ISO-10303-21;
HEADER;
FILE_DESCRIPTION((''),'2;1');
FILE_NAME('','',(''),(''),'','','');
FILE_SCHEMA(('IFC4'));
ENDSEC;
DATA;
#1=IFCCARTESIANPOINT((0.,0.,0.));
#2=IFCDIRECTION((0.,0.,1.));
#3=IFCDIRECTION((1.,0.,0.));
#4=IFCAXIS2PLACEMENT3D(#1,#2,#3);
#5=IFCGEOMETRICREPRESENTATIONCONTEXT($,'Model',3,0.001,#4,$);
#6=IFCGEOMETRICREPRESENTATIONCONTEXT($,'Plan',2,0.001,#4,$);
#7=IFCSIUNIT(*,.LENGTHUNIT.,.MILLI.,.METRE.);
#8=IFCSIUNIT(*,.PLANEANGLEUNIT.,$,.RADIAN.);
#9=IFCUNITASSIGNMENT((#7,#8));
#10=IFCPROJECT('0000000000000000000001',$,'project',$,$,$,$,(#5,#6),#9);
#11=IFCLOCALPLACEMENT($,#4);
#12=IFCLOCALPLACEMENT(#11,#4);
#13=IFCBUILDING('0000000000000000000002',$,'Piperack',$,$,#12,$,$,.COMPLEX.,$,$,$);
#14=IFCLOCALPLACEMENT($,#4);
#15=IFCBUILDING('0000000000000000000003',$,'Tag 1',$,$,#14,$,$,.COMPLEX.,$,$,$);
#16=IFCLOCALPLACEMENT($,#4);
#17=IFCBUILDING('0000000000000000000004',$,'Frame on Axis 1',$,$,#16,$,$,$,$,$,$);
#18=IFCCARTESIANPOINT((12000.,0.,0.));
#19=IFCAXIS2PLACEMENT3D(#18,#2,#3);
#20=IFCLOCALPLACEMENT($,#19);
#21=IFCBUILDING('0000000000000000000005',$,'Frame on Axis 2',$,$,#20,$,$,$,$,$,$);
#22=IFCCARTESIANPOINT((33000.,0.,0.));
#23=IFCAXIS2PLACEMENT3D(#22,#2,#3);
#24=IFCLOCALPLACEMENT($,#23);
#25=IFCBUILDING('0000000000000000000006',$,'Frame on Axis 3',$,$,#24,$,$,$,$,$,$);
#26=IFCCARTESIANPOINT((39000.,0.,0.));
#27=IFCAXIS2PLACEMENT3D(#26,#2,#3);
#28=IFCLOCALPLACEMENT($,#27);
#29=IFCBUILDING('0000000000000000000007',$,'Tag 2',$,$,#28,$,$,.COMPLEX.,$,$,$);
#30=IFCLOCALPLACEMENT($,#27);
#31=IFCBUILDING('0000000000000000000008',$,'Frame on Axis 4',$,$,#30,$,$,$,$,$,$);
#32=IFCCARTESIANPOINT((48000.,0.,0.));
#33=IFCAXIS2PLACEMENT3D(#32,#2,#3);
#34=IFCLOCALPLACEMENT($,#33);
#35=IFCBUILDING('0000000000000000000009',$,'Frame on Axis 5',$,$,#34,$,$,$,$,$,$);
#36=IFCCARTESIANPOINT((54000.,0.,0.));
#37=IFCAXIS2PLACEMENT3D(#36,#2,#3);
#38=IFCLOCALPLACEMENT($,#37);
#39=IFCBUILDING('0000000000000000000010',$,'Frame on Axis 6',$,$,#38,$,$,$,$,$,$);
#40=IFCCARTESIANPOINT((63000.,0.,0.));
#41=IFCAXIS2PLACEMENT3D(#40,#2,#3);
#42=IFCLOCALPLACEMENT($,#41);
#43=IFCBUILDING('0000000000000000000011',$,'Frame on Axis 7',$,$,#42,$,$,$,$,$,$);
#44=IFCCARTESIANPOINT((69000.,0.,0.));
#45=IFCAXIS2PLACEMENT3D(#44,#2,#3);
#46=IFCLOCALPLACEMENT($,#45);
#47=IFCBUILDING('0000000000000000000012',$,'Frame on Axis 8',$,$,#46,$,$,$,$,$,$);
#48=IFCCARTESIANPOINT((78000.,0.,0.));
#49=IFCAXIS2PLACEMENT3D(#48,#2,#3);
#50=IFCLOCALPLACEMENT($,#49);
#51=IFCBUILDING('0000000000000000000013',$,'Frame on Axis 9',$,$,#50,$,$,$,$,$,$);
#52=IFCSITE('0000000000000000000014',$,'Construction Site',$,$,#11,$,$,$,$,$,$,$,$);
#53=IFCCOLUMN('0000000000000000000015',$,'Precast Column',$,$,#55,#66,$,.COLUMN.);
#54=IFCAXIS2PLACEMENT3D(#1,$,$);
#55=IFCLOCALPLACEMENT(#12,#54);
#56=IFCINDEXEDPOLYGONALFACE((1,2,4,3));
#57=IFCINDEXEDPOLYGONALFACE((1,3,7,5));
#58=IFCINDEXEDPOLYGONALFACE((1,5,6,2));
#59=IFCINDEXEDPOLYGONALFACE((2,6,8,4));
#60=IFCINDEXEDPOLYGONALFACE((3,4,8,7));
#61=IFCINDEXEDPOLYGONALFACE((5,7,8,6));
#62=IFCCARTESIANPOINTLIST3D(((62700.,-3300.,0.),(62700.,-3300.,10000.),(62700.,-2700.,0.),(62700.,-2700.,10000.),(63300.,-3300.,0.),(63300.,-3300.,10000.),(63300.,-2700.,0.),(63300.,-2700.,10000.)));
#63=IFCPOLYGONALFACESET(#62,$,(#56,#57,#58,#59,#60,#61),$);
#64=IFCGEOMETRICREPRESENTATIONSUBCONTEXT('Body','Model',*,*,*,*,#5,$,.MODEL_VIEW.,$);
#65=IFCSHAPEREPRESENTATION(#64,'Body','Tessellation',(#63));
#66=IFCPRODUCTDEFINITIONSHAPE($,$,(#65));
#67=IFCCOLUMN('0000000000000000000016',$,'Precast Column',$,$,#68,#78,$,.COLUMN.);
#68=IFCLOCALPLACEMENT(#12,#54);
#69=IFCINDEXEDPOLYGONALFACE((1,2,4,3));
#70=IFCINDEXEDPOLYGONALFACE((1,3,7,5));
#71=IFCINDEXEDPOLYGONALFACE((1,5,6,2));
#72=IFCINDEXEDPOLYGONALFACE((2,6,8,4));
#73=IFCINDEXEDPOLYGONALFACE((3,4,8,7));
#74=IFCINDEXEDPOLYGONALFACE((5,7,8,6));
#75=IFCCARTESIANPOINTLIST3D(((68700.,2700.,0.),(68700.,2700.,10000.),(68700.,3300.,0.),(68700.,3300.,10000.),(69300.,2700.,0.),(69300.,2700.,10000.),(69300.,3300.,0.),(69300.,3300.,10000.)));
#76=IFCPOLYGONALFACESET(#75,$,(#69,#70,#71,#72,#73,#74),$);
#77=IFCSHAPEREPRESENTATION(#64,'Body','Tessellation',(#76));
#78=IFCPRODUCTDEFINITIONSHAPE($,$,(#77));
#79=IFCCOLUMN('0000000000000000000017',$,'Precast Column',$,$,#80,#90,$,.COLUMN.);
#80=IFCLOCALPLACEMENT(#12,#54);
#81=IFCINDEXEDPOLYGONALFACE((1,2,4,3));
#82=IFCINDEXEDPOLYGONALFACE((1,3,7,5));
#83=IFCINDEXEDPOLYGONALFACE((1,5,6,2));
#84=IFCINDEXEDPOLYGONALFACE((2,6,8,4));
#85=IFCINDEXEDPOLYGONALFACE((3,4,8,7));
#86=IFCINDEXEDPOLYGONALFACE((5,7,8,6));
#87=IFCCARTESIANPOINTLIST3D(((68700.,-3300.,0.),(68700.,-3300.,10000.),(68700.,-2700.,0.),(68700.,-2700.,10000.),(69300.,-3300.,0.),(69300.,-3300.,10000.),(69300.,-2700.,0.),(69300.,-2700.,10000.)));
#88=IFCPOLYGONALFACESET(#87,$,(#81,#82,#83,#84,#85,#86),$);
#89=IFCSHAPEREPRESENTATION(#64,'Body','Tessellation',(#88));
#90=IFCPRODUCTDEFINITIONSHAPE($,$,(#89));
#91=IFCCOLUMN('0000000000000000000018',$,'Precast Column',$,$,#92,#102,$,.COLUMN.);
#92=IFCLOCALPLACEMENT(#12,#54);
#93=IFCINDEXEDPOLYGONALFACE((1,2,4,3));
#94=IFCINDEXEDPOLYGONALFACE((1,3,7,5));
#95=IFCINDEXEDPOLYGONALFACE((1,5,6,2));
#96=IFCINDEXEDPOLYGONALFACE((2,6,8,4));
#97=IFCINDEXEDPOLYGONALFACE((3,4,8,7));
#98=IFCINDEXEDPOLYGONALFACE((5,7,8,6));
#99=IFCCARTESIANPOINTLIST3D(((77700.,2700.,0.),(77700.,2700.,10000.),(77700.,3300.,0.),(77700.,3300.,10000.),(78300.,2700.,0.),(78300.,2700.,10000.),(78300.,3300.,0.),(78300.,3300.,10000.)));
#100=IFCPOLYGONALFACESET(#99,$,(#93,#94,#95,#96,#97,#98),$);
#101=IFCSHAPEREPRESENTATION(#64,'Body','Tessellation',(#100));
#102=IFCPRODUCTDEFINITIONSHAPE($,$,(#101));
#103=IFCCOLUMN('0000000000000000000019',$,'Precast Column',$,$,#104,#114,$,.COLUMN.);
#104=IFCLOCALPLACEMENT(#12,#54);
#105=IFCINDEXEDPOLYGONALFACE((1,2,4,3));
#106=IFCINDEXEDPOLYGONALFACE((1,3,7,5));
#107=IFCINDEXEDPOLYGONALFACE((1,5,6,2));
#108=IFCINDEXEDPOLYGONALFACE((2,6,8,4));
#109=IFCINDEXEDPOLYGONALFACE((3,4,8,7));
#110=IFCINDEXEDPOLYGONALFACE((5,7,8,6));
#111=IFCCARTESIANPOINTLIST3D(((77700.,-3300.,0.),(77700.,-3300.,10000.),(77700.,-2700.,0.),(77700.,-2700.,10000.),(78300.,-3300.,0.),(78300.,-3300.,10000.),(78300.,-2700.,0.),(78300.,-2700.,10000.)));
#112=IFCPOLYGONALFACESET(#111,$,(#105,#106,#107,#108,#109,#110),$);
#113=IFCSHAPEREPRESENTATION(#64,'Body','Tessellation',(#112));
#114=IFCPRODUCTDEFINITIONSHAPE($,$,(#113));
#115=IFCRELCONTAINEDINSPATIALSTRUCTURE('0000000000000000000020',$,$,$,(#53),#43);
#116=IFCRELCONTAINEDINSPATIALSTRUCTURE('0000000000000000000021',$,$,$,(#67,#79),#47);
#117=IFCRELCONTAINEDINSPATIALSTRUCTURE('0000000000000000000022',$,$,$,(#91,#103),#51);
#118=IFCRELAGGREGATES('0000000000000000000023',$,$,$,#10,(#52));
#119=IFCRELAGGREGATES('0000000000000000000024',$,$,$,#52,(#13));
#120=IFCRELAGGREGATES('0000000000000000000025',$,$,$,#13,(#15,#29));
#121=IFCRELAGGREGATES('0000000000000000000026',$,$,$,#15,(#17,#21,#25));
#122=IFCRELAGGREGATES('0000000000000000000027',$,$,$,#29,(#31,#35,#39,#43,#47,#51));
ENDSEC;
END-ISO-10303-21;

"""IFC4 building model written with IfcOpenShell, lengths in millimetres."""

from ifc_helpers import new_model, si_unit, frame, origin, origin_with_axes, place, context, subcontext, project, spatial, rectangle, extrude, element, save


model = new_model("IFC4")

# Units and contexts
model_context = context("Model", 3, precision=0.001, world=origin_with_axes())
plan_context = context("Plan", 2, precision=0.001, world=origin_with_axes())
body_context = subcontext(model_context, "Body", "Model", "MODEL_VIEW")
ifc_project = project(units=[si_unit("LENGTHUNIT", "METRE", prefix="MILLI"), si_unit("PLANEANGLEUNIT", "RADIAN")], contexts=[model_context, plan_context])

# Site, buildings
site_placement = place(None, origin_with_axes())
site = spatial("IfcSite", under=ifc_project, at=site_placement, Name="Construction Site")
building_1_placement = place(site_placement, origin_with_axes())
building_1 = spatial("IfcBuilding", under=site, at=building_1_placement, Name="Piperack", CompositionType="COMPLEX")
building_2_placement = place(None, origin_with_axes())
building_2 = spatial("IfcBuilding", under=building_1, at=building_2_placement, Name="Tag 1", CompositionType="COMPLEX")
building_3_placement = place(None, origin_with_axes())
building_3 = spatial("IfcBuilding", under=building_2, at=building_3_placement, Name="Frame on Axis 1")

# Shared definitions
building_4_placement = place(None, frame((12000.0, 0.0, 0.0), z_axis=(0.0, 0.0, 1.0), x_axis=(1.0, 0.0, 0.0)))
building_4 = spatial("IfcBuilding", under=building_2, at=building_4_placement, Name="Frame on Axis 2")

# Shared definitions
building_5_placement = place(None, frame((33000.0, 0.0, 0.0), z_axis=(0.0, 0.0, 1.0), x_axis=(1.0, 0.0, 0.0)))
building_5 = spatial("IfcBuilding", under=building_2, at=building_5_placement, Name="Frame on Axis 3")

# Shared definitions
building_6_placement = place(None, frame((39000.0, 0.0, 0.0), z_axis=(0.0, 0.0, 1.0), x_axis=(1.0, 0.0, 0.0)))
building_6 = spatial("IfcBuilding", under=building_1, at=building_6_placement, Name="Tag 2", CompositionType="COMPLEX")
building_7_placement = place(None, frame((39000.0, 0.0, 0.0), z_axis=(0.0, 0.0, 1.0), x_axis=(1.0, 0.0, 0.0)))
building_7 = spatial("IfcBuilding", under=building_6, at=building_7_placement, Name="Frame on Axis 4")

# Shared definitions
building_8_placement = place(None, frame((48000.0, 0.0, 0.0), z_axis=(0.0, 0.0, 1.0), x_axis=(1.0, 0.0, 0.0)))
building_8 = spatial("IfcBuilding", under=building_6, at=building_8_placement, Name="Frame on Axis 5")

# Shared definitions
building_9_placement = place(None, frame((54000.0, 0.0, 0.0), z_axis=(0.0, 0.0, 1.0), x_axis=(1.0, 0.0, 0.0)))
building_9 = spatial("IfcBuilding", under=building_6, at=building_9_placement, Name="Frame on Axis 6")

# Shared definitions
building_10_placement = place(None, frame((63000.0, 0.0, 0.0), z_axis=(0.0, 0.0, 1.0), x_axis=(1.0, 0.0, 0.0)))
building_10 = spatial("IfcBuilding", under=building_6, at=building_10_placement, Name="Frame on Axis 7")

# Column
for number, where, z_axis, name in (
    (1, (0.0, -3000.0, 0.0), (0.0, 0.0, 1.0), "Precast Column"),
):
    element("IfcColumn", number, at=place(building_10_placement, frame(where, z_axis=z_axis)), inside=building_10, Name=name, PredefinedType="COLUMN", context=body_context, shape_type="SweptSolid", body=[
        extrude(rectangle(XDim=600.0, YDim=600.0), origin(), (0.0, 0.0, 1.0), 10000.0),
    ])

# Shared definitions
building_11_placement = place(None, frame((69000.0, 0.0, 0.0), z_axis=(0.0, 0.0, 1.0), x_axis=(1.0, 0.0, 0.0)))
building_11 = spatial("IfcBuilding", under=building_6, at=building_11_placement, Name="Frame on Axis 8")

# Columns
for number, where, z_axis, name in (
    (2, (0.0, 3000.0, 0.0), (0.0, 0.0, 1.0), "Precast Column"),
    (3, (0.0, -3000.0, 0.0), (0.0, 0.0, 1.0), "Precast Column"),
):
    element("IfcColumn", number, at=place(building_11_placement, frame(where, z_axis=z_axis)), inside=building_11, Name=name, PredefinedType="COLUMN", context=body_context, shape_type="SweptSolid", body=[
        extrude(rectangle(XDim=600.0, YDim=600.0), origin(), (0.0, 0.0, 1.0), 10000.0),
    ])

# Shared definitions
building_12_placement = place(None, frame((78000.0, 0.0, 0.0), z_axis=(0.0, 0.0, 1.0), x_axis=(1.0, 0.0, 0.0)))
building_12 = spatial("IfcBuilding", under=building_6, at=building_12_placement, Name="Frame on Axis 9")

# Columns
for number, where, z_axis, name in (
    (4, (0.0, 3000.0, 0.0), (0.0, 0.0, 1.0), "Precast Column"),
    (5, (0.0, -3000.0, 0.0), (0.0, 0.0, 1.0), "Precast Column"),
):
    element("IfcColumn", number, at=place(building_12_placement, frame(where, z_axis=z_axis)), inside=building_12, Name=name, PredefinedType="COLUMN", context=body_context, shape_type="SweptSolid", body=[
        extrude(rectangle(XDim=600.0, YDim=600.0), origin(), (0.0, 0.0, 1.0), 10000.0),
    ])

save(model, "model.ifc")
